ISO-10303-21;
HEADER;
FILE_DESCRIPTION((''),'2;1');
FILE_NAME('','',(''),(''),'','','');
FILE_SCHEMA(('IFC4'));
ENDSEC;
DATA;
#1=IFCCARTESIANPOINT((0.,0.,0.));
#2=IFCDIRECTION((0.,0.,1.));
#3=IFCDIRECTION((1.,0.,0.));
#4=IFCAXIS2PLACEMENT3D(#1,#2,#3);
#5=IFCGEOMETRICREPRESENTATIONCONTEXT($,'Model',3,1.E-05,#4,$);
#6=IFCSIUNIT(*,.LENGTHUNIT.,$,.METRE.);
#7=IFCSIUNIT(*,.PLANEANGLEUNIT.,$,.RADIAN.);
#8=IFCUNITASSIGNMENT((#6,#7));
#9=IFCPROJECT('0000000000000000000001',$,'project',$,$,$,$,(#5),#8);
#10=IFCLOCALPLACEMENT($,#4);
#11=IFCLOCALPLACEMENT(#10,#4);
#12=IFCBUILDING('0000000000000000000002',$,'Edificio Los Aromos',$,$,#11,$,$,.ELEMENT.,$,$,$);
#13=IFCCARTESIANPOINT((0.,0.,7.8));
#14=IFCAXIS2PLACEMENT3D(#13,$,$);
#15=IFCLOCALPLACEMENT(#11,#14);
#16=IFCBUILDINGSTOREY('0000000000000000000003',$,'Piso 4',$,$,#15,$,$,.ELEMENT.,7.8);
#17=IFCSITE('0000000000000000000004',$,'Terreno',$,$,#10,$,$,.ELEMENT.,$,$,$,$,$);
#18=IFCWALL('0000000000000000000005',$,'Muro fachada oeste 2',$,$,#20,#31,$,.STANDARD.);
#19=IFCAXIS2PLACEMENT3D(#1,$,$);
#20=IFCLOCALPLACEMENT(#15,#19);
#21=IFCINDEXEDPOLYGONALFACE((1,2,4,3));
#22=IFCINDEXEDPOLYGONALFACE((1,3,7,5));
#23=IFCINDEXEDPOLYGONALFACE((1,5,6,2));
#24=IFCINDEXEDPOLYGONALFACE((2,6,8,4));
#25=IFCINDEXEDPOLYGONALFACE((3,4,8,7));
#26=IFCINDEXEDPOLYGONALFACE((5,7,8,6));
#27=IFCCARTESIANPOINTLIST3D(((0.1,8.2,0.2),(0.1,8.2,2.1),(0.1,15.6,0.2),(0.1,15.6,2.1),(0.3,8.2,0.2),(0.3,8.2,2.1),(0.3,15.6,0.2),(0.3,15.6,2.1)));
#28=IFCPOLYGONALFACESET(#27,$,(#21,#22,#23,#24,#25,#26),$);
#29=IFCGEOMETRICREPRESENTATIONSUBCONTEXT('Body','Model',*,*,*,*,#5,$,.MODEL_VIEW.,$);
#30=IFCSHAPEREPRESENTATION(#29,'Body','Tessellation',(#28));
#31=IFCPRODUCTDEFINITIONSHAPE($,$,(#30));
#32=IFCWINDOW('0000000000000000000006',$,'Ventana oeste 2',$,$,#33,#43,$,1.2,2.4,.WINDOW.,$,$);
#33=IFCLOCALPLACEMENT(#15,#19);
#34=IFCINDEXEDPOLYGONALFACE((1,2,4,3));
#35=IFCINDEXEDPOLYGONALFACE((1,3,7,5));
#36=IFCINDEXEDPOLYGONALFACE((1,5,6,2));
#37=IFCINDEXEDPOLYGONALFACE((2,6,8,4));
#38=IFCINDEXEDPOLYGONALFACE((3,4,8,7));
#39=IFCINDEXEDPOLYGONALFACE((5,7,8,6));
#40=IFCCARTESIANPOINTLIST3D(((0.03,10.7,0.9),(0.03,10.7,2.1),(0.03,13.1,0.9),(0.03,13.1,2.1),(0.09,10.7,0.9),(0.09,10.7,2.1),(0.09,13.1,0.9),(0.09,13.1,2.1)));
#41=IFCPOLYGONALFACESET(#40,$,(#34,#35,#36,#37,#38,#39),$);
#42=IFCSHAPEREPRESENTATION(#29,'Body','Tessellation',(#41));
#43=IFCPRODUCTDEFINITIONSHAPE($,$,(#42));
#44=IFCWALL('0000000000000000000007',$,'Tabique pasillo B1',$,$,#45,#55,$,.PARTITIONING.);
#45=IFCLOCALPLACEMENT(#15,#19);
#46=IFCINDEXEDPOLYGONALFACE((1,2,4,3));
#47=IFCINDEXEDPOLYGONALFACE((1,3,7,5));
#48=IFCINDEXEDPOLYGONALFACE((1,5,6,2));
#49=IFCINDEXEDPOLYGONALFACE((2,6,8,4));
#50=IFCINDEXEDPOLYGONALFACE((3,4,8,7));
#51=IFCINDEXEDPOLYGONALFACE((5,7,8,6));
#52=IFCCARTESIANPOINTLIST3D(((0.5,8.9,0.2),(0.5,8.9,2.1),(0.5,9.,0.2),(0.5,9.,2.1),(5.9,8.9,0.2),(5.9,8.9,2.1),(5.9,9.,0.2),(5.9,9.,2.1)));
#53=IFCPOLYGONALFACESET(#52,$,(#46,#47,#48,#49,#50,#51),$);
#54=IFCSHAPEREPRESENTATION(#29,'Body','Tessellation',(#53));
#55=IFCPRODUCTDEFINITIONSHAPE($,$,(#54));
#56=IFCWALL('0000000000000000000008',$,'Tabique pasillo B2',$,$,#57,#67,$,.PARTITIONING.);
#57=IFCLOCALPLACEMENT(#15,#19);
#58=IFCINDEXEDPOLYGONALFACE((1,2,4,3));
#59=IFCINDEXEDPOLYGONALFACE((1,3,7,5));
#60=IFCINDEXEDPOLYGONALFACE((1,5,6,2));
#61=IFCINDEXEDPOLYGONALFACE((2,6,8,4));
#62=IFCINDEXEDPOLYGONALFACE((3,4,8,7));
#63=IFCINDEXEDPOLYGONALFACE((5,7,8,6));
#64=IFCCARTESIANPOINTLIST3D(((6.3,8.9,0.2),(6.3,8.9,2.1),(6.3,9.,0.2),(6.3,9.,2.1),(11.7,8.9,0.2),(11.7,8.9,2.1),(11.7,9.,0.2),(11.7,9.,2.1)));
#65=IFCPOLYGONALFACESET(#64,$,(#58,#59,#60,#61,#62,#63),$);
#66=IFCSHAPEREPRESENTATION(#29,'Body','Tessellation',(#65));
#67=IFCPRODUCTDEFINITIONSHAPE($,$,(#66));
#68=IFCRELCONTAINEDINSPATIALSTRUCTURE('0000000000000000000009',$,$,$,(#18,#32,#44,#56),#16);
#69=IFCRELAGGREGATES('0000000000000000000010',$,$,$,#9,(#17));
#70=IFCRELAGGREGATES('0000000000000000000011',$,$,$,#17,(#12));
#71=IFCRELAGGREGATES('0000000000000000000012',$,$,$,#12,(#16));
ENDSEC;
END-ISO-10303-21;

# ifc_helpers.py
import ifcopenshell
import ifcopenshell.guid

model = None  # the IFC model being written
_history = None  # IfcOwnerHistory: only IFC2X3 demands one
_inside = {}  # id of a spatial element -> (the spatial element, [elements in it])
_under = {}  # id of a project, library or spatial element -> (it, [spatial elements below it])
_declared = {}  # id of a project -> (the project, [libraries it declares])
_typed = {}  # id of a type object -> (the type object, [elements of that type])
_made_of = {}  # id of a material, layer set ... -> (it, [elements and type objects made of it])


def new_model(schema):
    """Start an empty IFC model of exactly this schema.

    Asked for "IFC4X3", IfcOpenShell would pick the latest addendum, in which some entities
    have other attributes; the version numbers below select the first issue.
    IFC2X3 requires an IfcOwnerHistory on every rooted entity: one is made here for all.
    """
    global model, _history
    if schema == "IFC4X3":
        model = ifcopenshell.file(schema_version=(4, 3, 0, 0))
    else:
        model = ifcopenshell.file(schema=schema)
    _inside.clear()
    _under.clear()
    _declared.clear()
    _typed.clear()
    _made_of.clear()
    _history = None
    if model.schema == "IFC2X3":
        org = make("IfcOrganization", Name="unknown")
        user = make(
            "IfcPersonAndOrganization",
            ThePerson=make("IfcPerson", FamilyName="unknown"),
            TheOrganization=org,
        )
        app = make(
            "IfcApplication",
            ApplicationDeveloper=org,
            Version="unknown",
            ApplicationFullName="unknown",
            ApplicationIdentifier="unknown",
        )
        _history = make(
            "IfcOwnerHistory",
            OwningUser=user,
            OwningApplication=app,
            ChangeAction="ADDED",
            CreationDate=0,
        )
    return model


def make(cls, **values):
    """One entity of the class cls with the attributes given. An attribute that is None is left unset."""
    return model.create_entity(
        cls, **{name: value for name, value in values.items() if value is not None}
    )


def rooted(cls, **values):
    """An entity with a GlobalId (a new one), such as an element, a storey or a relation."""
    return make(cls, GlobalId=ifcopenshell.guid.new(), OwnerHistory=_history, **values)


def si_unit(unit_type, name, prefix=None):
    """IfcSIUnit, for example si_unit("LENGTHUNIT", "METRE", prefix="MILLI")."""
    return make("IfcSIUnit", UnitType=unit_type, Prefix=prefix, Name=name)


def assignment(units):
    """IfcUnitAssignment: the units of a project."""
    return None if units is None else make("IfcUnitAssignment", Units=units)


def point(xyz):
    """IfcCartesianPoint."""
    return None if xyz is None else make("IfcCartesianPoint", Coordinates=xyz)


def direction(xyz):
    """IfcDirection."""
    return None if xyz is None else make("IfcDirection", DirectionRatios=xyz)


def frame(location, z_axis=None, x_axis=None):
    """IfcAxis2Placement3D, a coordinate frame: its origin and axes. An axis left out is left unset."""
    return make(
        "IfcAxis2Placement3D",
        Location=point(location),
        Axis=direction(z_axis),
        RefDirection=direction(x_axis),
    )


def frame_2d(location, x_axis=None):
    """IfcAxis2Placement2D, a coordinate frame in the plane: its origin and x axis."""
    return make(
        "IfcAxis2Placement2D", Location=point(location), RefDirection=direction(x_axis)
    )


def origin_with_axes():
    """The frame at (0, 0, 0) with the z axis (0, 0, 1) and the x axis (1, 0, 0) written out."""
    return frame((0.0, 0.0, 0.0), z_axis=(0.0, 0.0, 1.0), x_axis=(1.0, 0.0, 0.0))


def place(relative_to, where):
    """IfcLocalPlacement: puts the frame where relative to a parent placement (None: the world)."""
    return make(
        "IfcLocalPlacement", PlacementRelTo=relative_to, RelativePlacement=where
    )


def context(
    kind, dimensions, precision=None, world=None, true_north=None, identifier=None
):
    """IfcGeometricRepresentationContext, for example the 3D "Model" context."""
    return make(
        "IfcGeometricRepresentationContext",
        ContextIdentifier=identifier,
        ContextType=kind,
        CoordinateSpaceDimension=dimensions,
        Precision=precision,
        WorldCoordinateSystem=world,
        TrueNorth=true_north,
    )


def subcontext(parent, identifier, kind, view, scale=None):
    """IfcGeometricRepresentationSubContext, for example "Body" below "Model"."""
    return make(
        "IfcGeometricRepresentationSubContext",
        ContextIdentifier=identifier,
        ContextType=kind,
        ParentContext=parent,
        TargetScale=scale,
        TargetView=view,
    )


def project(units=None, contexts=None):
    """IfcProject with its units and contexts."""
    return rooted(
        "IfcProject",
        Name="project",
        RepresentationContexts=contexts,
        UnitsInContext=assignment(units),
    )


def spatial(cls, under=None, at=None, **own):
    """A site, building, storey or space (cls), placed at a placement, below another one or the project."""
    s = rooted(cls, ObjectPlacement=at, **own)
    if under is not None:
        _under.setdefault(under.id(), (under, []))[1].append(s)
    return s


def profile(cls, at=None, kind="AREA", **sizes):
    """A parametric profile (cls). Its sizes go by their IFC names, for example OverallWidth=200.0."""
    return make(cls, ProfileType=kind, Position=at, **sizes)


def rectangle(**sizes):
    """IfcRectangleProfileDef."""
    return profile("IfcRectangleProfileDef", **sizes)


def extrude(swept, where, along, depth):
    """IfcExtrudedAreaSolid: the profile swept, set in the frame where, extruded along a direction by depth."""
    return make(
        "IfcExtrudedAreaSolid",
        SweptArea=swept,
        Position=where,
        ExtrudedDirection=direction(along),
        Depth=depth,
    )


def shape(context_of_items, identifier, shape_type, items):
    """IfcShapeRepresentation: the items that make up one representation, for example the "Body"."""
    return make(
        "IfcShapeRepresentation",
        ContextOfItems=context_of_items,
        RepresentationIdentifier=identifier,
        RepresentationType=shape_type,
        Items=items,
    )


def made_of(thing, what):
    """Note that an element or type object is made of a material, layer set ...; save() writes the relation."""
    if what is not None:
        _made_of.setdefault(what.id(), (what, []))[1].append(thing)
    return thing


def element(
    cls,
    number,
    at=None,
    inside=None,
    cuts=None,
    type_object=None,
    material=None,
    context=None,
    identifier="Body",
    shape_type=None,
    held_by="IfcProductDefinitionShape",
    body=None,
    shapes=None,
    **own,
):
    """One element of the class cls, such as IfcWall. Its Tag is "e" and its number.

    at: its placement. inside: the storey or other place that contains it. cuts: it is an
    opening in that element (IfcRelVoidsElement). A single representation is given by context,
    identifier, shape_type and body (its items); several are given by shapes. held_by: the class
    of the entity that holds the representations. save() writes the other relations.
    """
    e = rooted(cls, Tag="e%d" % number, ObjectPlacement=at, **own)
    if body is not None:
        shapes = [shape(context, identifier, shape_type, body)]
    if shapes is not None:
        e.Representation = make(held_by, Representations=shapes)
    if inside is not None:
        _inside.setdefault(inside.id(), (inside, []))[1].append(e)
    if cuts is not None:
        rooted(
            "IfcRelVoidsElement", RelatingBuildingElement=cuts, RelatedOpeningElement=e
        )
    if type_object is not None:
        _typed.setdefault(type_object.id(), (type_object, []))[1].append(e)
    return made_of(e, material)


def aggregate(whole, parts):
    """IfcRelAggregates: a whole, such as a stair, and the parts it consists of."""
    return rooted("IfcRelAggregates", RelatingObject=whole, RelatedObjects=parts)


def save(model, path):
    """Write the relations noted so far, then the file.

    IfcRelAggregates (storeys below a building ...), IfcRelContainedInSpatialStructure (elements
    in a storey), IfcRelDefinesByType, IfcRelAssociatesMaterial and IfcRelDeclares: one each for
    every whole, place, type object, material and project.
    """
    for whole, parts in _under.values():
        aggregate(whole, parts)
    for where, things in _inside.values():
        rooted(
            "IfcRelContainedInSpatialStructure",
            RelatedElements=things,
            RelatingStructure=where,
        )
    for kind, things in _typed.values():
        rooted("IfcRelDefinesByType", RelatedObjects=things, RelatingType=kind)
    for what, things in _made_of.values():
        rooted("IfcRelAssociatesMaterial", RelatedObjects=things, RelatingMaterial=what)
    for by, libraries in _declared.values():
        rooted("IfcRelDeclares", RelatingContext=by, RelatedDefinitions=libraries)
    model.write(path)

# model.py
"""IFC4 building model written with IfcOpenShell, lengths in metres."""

from ifc_helpers import new_model, si_unit, frame, frame_2d, origin_with_axes, place, context, subcontext, project, spatial, rectangle, extrude, element, save


model = new_model("IFC4")

# Units and contexts
model_context = context("Model", 3, precision=1e-05, world=origin_with_axes())
body_context = subcontext(model_context, "Body", "Model", "MODEL_VIEW")
ifc_project = project(units=[si_unit("LENGTHUNIT", "METRE"), si_unit("PLANEANGLEUNIT", "RADIAN")], contexts=[model_context])

# Site, building, storey
site_placement = place(None, origin_with_axes())
site = spatial("IfcSite", under=ifc_project, at=site_placement, Name="Terreno", CompositionType="ELEMENT")
building_placement = place(site_placement, origin_with_axes())
building = spatial("IfcBuilding", under=site, at=building_placement, Name="Edificio Los Aromos", CompositionType="ELEMENT")
storey_placement = place(building_placement, frame((0.0, 0.0, 7.8)))
storey = spatial("IfcBuildingStorey", under=building, at=storey_placement, Name="Piso 4", CompositionType="ELEMENT", Elevation=7.8)

# Wall
wall_1_placement = place(storey_placement, frame((0.1, 8.2, 0.2)))
element("IfcWall", 1, at=wall_1_placement, inside=storey, Name="Muro fachada oeste 2", PredefinedType="STANDARD", context=body_context, shape_type="SweptSolid", body=[
    extrude(rectangle(XDim=0.2, YDim=7.4, at=frame_2d((0.1, 3.7))), origin_with_axes(), (0.0, 0.0, 1.0), 1.9),
])

# Window
window_1_placement = place(storey_placement, frame((0.03, 10.7, 0.9)))
element("IfcWindow", 2, at=window_1_placement, inside=storey, Name="Ventana oeste 2", OverallHeight=1.2, OverallWidth=2.4, PredefinedType="WINDOW", context=body_context, shape_type="SweptSolid", body=[
    extrude(rectangle(XDim=0.06, YDim=2.4, at=frame_2d((0.03, 1.2))), origin_with_axes(), (0.0, 0.0, 1.0), 1.2),
])

# Walls
for number, where, name in (
    (3, (0.5, 8.9, 0.2), "Tabique pasillo B1"),
    (4, (6.3, 8.9, 0.2), "Tabique pasillo B2"),
):
    element("IfcWall", number, at=place(storey_placement, frame(where)), inside=storey, Name=name, PredefinedType="PARTITIONING", context=body_context, shape_type="SweptSolid", body=[
        extrude(rectangle(XDim=5.4, YDim=0.1, at=frame_2d((2.7, 0.05))), origin_with_axes(), (0.0, 0.0, 1.0), 1.9),
    ])

save(model, "model.ifc")
